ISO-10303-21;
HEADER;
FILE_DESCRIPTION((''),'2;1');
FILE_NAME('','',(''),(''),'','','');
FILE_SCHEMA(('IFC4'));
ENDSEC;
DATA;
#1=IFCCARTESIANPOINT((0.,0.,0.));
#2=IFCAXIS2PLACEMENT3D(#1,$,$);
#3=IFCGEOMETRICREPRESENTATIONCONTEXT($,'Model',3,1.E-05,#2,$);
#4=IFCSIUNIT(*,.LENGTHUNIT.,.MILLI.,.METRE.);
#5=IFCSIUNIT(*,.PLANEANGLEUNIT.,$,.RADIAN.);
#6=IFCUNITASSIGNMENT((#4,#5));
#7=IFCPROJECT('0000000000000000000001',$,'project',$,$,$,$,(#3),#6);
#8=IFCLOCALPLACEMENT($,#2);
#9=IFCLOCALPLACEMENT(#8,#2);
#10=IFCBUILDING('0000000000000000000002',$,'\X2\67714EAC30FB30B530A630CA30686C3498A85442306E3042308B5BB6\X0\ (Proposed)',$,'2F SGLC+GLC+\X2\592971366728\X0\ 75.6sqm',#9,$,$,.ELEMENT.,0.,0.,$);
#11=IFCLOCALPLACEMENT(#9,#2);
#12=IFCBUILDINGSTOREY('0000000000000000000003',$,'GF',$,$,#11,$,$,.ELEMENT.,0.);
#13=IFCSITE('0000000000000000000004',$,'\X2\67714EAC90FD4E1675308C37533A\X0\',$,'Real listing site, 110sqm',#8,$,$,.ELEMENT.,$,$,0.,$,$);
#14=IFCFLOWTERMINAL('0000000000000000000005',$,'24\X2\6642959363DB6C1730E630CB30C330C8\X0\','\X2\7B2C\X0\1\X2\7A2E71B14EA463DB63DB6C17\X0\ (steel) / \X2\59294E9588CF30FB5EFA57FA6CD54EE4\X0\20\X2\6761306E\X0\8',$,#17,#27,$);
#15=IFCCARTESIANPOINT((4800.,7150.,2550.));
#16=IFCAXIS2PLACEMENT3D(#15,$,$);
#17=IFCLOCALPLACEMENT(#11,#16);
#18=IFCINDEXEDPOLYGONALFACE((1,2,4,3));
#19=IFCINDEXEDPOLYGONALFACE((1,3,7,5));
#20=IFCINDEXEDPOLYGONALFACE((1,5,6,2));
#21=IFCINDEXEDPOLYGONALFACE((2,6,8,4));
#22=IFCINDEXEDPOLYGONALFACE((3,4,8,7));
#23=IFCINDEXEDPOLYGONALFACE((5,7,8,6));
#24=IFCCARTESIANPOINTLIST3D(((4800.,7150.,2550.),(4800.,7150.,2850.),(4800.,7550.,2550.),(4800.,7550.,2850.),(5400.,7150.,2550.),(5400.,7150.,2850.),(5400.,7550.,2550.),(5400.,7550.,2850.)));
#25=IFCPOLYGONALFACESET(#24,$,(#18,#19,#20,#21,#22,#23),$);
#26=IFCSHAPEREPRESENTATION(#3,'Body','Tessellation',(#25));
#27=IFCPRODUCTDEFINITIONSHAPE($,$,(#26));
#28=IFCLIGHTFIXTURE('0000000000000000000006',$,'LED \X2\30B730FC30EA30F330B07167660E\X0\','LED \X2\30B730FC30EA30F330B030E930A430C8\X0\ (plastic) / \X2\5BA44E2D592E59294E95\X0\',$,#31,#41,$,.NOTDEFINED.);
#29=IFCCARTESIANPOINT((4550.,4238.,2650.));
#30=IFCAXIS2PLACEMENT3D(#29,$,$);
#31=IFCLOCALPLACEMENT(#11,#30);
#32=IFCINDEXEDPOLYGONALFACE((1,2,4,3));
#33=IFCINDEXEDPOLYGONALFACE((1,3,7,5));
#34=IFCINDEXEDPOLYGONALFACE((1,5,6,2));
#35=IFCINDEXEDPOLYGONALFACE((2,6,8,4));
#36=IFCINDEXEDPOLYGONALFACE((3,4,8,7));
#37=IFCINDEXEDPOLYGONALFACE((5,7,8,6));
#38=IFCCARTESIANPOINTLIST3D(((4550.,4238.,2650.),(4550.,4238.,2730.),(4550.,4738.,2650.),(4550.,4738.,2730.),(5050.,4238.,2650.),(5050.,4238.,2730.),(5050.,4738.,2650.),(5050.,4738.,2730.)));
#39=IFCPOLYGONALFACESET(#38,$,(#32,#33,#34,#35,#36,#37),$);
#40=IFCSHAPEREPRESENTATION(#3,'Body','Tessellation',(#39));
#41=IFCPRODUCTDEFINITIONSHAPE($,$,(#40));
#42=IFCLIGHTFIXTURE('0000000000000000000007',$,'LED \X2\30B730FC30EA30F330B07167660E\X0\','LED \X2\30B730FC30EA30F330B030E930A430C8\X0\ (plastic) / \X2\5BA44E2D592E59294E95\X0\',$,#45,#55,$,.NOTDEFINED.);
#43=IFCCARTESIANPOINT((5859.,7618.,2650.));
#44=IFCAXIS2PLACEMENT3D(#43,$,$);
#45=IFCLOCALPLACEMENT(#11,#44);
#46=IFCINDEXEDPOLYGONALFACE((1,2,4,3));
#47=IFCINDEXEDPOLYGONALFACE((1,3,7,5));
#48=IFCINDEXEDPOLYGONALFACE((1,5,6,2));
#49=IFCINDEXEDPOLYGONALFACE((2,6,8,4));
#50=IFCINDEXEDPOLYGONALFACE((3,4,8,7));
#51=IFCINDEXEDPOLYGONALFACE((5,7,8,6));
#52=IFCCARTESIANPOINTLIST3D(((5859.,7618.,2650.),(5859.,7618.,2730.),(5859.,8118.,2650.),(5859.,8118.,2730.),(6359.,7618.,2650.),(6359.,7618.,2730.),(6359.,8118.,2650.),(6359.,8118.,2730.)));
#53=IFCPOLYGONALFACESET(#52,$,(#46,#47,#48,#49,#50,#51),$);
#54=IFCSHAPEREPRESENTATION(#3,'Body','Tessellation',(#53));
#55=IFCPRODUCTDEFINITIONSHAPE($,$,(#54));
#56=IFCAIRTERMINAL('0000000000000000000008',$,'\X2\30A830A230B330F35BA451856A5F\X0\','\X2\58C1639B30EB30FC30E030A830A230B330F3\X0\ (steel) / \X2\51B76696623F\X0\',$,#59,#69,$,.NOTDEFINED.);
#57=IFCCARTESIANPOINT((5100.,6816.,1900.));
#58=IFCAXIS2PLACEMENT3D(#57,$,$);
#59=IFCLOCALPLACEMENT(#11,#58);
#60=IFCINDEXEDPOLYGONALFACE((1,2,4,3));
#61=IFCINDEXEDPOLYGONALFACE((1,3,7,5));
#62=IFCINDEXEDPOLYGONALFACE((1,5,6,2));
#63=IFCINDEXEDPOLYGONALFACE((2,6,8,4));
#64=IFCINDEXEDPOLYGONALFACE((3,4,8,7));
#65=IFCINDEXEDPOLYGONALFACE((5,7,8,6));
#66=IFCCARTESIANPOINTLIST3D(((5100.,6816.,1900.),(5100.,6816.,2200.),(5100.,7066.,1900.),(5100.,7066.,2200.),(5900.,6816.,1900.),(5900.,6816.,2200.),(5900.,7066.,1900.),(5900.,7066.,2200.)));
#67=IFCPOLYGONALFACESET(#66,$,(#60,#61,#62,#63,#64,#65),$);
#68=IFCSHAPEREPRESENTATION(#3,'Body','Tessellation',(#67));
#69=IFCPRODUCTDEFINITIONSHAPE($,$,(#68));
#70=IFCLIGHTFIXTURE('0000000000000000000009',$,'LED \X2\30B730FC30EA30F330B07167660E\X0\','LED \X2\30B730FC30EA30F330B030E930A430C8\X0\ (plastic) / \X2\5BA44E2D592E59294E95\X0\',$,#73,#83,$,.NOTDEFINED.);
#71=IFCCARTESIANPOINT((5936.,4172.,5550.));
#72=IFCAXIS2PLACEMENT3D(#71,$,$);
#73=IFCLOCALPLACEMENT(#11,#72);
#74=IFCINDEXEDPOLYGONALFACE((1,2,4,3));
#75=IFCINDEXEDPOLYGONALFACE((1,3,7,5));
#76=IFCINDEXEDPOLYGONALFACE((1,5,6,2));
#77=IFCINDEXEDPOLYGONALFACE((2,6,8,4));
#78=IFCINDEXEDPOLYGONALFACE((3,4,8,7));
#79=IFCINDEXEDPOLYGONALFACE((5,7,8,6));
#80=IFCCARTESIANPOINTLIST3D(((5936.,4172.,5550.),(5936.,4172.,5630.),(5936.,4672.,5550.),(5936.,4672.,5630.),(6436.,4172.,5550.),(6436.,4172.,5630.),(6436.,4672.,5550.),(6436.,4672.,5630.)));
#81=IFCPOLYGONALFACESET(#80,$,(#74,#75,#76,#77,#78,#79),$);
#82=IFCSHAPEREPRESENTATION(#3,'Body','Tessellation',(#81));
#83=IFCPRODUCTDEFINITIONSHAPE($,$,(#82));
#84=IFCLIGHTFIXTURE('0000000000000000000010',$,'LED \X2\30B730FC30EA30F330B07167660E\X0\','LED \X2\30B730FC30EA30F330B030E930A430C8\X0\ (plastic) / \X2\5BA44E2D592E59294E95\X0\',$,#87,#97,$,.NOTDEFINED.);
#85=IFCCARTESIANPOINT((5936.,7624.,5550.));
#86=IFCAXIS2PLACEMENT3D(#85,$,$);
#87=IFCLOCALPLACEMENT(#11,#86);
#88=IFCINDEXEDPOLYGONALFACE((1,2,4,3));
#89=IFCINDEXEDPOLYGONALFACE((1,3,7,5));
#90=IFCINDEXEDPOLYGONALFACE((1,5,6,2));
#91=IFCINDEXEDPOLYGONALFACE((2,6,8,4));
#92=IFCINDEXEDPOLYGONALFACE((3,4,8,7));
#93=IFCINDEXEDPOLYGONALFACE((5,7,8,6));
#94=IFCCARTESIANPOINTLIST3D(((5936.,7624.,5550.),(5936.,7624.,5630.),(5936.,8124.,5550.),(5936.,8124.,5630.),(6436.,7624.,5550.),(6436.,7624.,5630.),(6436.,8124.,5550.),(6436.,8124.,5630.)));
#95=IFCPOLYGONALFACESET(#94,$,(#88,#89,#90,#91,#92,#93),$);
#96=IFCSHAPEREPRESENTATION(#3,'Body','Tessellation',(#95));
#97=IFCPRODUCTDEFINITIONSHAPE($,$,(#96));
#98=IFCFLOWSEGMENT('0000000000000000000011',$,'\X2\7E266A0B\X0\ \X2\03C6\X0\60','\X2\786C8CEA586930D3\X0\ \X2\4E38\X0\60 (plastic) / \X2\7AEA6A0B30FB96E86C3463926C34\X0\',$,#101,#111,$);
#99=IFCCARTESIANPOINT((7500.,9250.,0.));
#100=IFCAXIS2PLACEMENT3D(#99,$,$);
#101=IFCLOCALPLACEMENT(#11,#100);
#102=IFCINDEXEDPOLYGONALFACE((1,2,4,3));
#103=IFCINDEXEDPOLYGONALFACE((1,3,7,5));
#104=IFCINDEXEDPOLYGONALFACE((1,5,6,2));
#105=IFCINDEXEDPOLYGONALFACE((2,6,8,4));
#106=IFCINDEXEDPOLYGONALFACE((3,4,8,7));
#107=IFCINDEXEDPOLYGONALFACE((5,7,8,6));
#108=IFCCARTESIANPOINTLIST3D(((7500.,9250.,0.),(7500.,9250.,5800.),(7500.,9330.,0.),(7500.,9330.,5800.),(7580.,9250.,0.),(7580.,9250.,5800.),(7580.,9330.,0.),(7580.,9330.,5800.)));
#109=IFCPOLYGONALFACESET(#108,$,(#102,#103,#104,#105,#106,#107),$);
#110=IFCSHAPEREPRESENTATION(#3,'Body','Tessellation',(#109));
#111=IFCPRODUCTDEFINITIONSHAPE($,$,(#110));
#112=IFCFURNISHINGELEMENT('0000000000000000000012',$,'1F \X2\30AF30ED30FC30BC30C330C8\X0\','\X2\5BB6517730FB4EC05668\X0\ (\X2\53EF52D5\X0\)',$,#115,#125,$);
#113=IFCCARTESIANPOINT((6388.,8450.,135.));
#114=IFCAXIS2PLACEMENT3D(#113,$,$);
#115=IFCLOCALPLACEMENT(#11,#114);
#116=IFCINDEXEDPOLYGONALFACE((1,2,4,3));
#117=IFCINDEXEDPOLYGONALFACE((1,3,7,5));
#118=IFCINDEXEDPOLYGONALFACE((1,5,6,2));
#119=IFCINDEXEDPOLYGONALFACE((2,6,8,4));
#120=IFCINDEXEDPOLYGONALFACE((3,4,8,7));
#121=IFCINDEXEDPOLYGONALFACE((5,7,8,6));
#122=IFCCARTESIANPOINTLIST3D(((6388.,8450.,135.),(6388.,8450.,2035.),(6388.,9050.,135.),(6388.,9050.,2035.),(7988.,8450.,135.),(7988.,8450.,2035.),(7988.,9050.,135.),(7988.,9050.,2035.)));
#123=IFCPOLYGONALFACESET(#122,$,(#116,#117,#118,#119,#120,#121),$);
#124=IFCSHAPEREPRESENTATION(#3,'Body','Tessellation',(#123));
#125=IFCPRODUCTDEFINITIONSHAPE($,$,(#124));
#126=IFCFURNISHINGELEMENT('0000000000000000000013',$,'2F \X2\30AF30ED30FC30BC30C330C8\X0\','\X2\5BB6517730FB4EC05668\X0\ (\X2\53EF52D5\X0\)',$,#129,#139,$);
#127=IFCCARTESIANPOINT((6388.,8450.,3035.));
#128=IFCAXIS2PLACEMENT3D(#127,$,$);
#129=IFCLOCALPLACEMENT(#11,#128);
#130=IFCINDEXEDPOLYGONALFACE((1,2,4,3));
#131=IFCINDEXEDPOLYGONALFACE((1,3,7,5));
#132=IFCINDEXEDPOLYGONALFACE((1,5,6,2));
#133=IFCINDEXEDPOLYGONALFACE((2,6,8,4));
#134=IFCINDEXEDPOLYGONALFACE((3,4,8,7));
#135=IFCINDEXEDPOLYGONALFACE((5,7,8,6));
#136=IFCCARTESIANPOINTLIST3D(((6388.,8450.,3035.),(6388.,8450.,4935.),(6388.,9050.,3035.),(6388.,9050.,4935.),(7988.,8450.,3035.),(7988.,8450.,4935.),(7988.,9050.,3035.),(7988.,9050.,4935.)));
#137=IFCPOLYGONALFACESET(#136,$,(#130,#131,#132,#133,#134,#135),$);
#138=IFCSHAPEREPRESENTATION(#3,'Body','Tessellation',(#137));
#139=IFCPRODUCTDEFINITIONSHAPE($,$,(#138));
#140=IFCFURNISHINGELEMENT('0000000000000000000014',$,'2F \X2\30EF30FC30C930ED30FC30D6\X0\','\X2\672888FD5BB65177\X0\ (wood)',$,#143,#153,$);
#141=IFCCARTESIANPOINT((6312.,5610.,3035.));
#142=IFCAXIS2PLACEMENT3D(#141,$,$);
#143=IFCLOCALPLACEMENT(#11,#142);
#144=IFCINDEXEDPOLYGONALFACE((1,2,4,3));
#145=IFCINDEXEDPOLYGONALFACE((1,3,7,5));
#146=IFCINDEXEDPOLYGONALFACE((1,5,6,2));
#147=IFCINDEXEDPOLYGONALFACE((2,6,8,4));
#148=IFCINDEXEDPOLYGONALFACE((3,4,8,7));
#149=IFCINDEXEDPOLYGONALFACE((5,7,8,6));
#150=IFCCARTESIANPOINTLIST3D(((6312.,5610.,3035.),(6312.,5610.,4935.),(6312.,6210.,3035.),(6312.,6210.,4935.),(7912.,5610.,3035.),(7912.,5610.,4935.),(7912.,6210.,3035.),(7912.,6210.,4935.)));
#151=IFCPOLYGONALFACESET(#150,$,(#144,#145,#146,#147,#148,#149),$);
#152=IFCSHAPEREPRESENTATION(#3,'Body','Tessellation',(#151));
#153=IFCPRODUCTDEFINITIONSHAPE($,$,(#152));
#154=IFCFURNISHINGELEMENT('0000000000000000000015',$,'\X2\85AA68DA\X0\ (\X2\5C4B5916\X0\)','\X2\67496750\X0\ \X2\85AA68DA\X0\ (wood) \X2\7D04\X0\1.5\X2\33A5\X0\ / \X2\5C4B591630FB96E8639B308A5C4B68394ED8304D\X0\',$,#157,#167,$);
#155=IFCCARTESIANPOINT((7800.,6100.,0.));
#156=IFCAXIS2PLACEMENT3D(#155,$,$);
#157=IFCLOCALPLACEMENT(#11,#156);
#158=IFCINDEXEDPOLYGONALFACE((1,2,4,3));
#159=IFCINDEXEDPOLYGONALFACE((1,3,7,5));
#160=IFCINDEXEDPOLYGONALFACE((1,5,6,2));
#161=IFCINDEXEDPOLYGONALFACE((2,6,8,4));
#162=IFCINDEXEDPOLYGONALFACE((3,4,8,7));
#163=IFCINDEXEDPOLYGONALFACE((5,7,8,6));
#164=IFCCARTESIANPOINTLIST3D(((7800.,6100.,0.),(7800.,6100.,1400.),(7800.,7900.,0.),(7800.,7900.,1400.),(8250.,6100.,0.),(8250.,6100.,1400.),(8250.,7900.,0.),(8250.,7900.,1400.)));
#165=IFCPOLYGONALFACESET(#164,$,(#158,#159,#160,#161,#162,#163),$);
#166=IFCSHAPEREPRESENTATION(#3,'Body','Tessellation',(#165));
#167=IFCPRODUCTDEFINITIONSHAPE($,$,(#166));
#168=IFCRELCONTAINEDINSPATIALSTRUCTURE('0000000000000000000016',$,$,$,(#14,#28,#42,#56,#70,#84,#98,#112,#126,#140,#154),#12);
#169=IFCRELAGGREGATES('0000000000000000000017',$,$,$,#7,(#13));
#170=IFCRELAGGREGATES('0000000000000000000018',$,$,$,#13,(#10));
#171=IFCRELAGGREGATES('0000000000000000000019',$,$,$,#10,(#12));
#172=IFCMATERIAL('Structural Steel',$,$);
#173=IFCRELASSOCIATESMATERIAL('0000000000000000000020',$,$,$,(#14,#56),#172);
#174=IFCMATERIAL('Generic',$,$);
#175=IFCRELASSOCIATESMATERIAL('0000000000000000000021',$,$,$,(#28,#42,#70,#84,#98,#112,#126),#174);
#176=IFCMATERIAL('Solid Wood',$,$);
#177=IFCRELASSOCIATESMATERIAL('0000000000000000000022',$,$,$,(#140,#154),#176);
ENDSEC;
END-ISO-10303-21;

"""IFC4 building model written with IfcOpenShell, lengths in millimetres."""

from ifc_helpers import new_model, si_unit, frame, frame_2d, origin, place, context, project, spatial, rectangle, extrude, material, element, save


model = new_model("IFC4")

# Units and contexts
model_context = context("Model", 3, precision=1e-05, world=origin())
ifc_project = project(units=[si_unit("LENGTHUNIT", "METRE", prefix="MILLI"), si_unit("PLANEANGLEUNIT", "RADIAN")], contexts=[model_context])

# Site, building, storey
site_placement = place(None, origin())
site = spatial("IfcSite", under=ifc_project, at=site_placement, Name="東京都世田谷区", ObjectType="Real listing site, 110sqm", CompositionType="ELEMENT", RefElevation=0.0)
building_placement = place(site_placement, origin())
building = spatial("IfcBuilding", under=site, at=building_placement, Name="東京・サウナと水風呂のある家 (Proposed)", ObjectType="2F SGLC+GLC+天然木 75.6sqm", CompositionType="ELEMENT", ElevationOfRefHeight=0.0, ElevationOfTerrain=0.0)
storey_placement = place(building_placement, origin())
storey = spatial("IfcBuildingStorey", under=building, at=storey_placement, Name="GF", CompositionType="ELEMENT", Elevation=0.0)

# Shared definitions
ifc_material_1 = material(Name="Solid Wood")

# Shared definitions
ifc_material_2 = material(Name="Structural Steel")

# Shared definitions
ifc_material_3 = material(Name="Generic")

# Flow terminal
flow_terminal_placement = place(storey_placement, frame((4800.0, 7150.0, 2550.0)))
element("IfcFlowTerminal", 1, at=flow_terminal_placement, inside=storey, material=ifc_material_2, Name="24時間換気ユニット", Description="第1種熱交換換気 (steel) / 天井裏・建基法令20条の8", context=model_context, shape_type="SweptSolid", body=[
    extrude(rectangle(XDim=600.0, YDim=400.0, at=frame_2d((300.0, 200.0))), frame((4800.0, 7150.0, 2550.0)), (0.0, 0.0, 1.0), 300.0),
])

# Light fixtures
light_fixture_1_placement = place(storey_placement, frame((4550.0, 4238.0, 2650.0)))
element("IfcLightFixture", 2, at=light_fixture_1_placement, inside=storey, material=ifc_material_3, Name="LED シーリング照明", Description="LED シーリングライト (plastic) / 室中央天井", PredefinedType="NOTDEFINED", context=model_context, shape_type="SweptSolid", body=[
    extrude(rectangle(XDim=500.0, YDim=500.0, at=frame_2d((250.0, 250.0))), frame((4550.0, 4238.0, 2650.0)), (0.0, 0.0, 1.0), 80.0),
])
light_fixture_2_placement = place(storey_placement, frame((5859.0, 7618.0, 2650.0)))
element("IfcLightFixture", 3, at=light_fixture_2_placement, inside=storey, material=ifc_material_3, Name="LED シーリング照明", Description="LED シーリングライト (plastic) / 室中央天井", PredefinedType="NOTDEFINED", context=model_context, shape_type="SweptSolid", body=[
    extrude(rectangle(XDim=500.0, YDim=500.0, at=frame_2d((250.0, 250.0))), frame((5859.0, 7618.0, 2650.0)), (0.0, 0.0, 1.0), 80.0),
])

# Air terminal
air_terminal_placement = place(storey_placement, frame((5100.0, 6816.0, 1900.0)))
element("IfcAirTerminal", 4, at=air_terminal_placement, inside=storey, material=ifc_material_2, Name="エアコン室内機", Description="壁掛ルームエアコン (steel) / 冷暖房", PredefinedType="NOTDEFINED", context=model_context, shape_type="SweptSolid", body=[
    extrude(rectangle(XDim=800.0, YDim=250.0, at=frame_2d((400.0, 125.0))), frame((5100.0, 6816.0, 1900.0)), (0.0, 0.0, 1.0), 300.0),
])

# Light fixtures
light_fixture_3_placement = place(storey_placement, frame((5936.0, 4172.0, 5550.0)))
element("IfcLightFixture", 5, at=light_fixture_3_placement, inside=storey, material=ifc_material_3, Name="LED シーリング照明", Description="LED シーリングライト (plastic) / 室中央天井", PredefinedType="NOTDEFINED", context=model_context, shape_type="SweptSolid", body=[
    extrude(rectangle(XDim=500.0, YDim=500.0, at=frame_2d((250.0, 250.0))), frame((5936.0, 4172.0, 5550.0)), (0.0, 0.0, 1.0), 80.0),
])
light_fixture_4_placement = place(storey_placement, frame((5936.0, 7624.0, 5550.0)))
element("IfcLightFixture", 6, at=light_fixture_4_placement, inside=storey, material=ifc_material_3, Name="LED シーリング照明", Description="LED シーリングライト (plastic) / 室中央天井", PredefinedType="NOTDEFINED", context=model_context, shape_type="SweptSolid", body=[
    extrude(rectangle(XDim=500.0, YDim=500.0, at=frame_2d((250.0, 250.0))), frame((5936.0, 7624.0, 5550.0)), (0.0, 0.0, 1.0), 80.0),
])

# Flow segment
flow_segment_placement = place(storey_placement, frame((7500.0, 9250.0, 0.0)))
element("IfcFlowSegment", 7, at=flow_segment_placement, inside=storey, material=ifc_material_3, Name="縦樋 φ60", Description="硬質塩ビ 丸60 (plastic) / 竪樋・雨水排水", context=model_context, shape_type="SweptSolid", body=[
    extrude(rectangle(XDim=80.0, YDim=80.0, at=frame_2d((40.0, 40.0))), frame((7500.0, 9250.0, 0.0)), (0.0, 0.0, 1.0), 5800.0),
])

# Furnishing elements
furnishing_1_placement = place(storey_placement, frame((6388.0, 8450.0, 135.0)))
element("IfcFurnishingElement", 8, at=furnishing_1_placement, inside=storey, material=ifc_material_3, Name="1F クローゼット", Description="家具・什器 (可動)", context=model_context, shape_type="SweptSolid", body=[
    extrude(rectangle(XDim=1600.0, YDim=600.0, at=frame_2d((800.0, 300.0))), frame((6388.0, 8450.0, 135.0)), (0.0, 0.0, 1.0), 1900.0),
])
furnishing_2_placement = place(storey_placement, frame((6388.0, 8450.0, 3035.0)))
element("IfcFurnishingElement", 9, at=furnishing_2_placement, inside=storey, material=ifc_material_3, Name="2F クローゼット", Description="家具・什器 (可動)", context=model_context, shape_type="SweptSolid", body=[
    extrude(rectangle(XDim=1600.0, YDim=600.0, at=frame_2d((800.0, 300.0))), frame((6388.0, 8450.0, 3035.0)), (0.0, 0.0, 1.0), 1900.0),
])
furnishing_3_placement = place(storey_placement, frame((6312.0, 5610.0, 3035.0)))
element("IfcFurnishingElement", 10, at=furnishing_3_placement, inside=storey, material=ifc_material_1, Name="2F ワードローブ", Description="木製家具 (wood)", context=model_context, shape_type="SweptSolid", body=[
    extrude(rectangle(XDim=1600.0, YDim=600.0, at=frame_2d((800.0, 300.0))), frame((6312.0, 5610.0, 3035.0)), (0.0, 0.0, 1.0), 1900.0),
])
furnishing_4_placement = place(storey_placement, frame((7800.0, 6100.0, 0.0)))
element("IfcFurnishingElement", 11, at=furnishing_4_placement, inside=storey, material=ifc_material_1, Name="薪棚 (屋外)", Description="杉材 薪棚 (wood) 約1.5㎥ / 屋外・雨掛り屋根付き", context=model_context, shape_type="SweptSolid", body=[
    extrude(rectangle(XDim=450.0, YDim=1800.0, at=frame_2d((225.0, 900.0))), frame((7800.0, 6100.0, 0.0)), (0.0, 0.0, 1.0), 1400.0),
])

save(model, "model.ifc")
